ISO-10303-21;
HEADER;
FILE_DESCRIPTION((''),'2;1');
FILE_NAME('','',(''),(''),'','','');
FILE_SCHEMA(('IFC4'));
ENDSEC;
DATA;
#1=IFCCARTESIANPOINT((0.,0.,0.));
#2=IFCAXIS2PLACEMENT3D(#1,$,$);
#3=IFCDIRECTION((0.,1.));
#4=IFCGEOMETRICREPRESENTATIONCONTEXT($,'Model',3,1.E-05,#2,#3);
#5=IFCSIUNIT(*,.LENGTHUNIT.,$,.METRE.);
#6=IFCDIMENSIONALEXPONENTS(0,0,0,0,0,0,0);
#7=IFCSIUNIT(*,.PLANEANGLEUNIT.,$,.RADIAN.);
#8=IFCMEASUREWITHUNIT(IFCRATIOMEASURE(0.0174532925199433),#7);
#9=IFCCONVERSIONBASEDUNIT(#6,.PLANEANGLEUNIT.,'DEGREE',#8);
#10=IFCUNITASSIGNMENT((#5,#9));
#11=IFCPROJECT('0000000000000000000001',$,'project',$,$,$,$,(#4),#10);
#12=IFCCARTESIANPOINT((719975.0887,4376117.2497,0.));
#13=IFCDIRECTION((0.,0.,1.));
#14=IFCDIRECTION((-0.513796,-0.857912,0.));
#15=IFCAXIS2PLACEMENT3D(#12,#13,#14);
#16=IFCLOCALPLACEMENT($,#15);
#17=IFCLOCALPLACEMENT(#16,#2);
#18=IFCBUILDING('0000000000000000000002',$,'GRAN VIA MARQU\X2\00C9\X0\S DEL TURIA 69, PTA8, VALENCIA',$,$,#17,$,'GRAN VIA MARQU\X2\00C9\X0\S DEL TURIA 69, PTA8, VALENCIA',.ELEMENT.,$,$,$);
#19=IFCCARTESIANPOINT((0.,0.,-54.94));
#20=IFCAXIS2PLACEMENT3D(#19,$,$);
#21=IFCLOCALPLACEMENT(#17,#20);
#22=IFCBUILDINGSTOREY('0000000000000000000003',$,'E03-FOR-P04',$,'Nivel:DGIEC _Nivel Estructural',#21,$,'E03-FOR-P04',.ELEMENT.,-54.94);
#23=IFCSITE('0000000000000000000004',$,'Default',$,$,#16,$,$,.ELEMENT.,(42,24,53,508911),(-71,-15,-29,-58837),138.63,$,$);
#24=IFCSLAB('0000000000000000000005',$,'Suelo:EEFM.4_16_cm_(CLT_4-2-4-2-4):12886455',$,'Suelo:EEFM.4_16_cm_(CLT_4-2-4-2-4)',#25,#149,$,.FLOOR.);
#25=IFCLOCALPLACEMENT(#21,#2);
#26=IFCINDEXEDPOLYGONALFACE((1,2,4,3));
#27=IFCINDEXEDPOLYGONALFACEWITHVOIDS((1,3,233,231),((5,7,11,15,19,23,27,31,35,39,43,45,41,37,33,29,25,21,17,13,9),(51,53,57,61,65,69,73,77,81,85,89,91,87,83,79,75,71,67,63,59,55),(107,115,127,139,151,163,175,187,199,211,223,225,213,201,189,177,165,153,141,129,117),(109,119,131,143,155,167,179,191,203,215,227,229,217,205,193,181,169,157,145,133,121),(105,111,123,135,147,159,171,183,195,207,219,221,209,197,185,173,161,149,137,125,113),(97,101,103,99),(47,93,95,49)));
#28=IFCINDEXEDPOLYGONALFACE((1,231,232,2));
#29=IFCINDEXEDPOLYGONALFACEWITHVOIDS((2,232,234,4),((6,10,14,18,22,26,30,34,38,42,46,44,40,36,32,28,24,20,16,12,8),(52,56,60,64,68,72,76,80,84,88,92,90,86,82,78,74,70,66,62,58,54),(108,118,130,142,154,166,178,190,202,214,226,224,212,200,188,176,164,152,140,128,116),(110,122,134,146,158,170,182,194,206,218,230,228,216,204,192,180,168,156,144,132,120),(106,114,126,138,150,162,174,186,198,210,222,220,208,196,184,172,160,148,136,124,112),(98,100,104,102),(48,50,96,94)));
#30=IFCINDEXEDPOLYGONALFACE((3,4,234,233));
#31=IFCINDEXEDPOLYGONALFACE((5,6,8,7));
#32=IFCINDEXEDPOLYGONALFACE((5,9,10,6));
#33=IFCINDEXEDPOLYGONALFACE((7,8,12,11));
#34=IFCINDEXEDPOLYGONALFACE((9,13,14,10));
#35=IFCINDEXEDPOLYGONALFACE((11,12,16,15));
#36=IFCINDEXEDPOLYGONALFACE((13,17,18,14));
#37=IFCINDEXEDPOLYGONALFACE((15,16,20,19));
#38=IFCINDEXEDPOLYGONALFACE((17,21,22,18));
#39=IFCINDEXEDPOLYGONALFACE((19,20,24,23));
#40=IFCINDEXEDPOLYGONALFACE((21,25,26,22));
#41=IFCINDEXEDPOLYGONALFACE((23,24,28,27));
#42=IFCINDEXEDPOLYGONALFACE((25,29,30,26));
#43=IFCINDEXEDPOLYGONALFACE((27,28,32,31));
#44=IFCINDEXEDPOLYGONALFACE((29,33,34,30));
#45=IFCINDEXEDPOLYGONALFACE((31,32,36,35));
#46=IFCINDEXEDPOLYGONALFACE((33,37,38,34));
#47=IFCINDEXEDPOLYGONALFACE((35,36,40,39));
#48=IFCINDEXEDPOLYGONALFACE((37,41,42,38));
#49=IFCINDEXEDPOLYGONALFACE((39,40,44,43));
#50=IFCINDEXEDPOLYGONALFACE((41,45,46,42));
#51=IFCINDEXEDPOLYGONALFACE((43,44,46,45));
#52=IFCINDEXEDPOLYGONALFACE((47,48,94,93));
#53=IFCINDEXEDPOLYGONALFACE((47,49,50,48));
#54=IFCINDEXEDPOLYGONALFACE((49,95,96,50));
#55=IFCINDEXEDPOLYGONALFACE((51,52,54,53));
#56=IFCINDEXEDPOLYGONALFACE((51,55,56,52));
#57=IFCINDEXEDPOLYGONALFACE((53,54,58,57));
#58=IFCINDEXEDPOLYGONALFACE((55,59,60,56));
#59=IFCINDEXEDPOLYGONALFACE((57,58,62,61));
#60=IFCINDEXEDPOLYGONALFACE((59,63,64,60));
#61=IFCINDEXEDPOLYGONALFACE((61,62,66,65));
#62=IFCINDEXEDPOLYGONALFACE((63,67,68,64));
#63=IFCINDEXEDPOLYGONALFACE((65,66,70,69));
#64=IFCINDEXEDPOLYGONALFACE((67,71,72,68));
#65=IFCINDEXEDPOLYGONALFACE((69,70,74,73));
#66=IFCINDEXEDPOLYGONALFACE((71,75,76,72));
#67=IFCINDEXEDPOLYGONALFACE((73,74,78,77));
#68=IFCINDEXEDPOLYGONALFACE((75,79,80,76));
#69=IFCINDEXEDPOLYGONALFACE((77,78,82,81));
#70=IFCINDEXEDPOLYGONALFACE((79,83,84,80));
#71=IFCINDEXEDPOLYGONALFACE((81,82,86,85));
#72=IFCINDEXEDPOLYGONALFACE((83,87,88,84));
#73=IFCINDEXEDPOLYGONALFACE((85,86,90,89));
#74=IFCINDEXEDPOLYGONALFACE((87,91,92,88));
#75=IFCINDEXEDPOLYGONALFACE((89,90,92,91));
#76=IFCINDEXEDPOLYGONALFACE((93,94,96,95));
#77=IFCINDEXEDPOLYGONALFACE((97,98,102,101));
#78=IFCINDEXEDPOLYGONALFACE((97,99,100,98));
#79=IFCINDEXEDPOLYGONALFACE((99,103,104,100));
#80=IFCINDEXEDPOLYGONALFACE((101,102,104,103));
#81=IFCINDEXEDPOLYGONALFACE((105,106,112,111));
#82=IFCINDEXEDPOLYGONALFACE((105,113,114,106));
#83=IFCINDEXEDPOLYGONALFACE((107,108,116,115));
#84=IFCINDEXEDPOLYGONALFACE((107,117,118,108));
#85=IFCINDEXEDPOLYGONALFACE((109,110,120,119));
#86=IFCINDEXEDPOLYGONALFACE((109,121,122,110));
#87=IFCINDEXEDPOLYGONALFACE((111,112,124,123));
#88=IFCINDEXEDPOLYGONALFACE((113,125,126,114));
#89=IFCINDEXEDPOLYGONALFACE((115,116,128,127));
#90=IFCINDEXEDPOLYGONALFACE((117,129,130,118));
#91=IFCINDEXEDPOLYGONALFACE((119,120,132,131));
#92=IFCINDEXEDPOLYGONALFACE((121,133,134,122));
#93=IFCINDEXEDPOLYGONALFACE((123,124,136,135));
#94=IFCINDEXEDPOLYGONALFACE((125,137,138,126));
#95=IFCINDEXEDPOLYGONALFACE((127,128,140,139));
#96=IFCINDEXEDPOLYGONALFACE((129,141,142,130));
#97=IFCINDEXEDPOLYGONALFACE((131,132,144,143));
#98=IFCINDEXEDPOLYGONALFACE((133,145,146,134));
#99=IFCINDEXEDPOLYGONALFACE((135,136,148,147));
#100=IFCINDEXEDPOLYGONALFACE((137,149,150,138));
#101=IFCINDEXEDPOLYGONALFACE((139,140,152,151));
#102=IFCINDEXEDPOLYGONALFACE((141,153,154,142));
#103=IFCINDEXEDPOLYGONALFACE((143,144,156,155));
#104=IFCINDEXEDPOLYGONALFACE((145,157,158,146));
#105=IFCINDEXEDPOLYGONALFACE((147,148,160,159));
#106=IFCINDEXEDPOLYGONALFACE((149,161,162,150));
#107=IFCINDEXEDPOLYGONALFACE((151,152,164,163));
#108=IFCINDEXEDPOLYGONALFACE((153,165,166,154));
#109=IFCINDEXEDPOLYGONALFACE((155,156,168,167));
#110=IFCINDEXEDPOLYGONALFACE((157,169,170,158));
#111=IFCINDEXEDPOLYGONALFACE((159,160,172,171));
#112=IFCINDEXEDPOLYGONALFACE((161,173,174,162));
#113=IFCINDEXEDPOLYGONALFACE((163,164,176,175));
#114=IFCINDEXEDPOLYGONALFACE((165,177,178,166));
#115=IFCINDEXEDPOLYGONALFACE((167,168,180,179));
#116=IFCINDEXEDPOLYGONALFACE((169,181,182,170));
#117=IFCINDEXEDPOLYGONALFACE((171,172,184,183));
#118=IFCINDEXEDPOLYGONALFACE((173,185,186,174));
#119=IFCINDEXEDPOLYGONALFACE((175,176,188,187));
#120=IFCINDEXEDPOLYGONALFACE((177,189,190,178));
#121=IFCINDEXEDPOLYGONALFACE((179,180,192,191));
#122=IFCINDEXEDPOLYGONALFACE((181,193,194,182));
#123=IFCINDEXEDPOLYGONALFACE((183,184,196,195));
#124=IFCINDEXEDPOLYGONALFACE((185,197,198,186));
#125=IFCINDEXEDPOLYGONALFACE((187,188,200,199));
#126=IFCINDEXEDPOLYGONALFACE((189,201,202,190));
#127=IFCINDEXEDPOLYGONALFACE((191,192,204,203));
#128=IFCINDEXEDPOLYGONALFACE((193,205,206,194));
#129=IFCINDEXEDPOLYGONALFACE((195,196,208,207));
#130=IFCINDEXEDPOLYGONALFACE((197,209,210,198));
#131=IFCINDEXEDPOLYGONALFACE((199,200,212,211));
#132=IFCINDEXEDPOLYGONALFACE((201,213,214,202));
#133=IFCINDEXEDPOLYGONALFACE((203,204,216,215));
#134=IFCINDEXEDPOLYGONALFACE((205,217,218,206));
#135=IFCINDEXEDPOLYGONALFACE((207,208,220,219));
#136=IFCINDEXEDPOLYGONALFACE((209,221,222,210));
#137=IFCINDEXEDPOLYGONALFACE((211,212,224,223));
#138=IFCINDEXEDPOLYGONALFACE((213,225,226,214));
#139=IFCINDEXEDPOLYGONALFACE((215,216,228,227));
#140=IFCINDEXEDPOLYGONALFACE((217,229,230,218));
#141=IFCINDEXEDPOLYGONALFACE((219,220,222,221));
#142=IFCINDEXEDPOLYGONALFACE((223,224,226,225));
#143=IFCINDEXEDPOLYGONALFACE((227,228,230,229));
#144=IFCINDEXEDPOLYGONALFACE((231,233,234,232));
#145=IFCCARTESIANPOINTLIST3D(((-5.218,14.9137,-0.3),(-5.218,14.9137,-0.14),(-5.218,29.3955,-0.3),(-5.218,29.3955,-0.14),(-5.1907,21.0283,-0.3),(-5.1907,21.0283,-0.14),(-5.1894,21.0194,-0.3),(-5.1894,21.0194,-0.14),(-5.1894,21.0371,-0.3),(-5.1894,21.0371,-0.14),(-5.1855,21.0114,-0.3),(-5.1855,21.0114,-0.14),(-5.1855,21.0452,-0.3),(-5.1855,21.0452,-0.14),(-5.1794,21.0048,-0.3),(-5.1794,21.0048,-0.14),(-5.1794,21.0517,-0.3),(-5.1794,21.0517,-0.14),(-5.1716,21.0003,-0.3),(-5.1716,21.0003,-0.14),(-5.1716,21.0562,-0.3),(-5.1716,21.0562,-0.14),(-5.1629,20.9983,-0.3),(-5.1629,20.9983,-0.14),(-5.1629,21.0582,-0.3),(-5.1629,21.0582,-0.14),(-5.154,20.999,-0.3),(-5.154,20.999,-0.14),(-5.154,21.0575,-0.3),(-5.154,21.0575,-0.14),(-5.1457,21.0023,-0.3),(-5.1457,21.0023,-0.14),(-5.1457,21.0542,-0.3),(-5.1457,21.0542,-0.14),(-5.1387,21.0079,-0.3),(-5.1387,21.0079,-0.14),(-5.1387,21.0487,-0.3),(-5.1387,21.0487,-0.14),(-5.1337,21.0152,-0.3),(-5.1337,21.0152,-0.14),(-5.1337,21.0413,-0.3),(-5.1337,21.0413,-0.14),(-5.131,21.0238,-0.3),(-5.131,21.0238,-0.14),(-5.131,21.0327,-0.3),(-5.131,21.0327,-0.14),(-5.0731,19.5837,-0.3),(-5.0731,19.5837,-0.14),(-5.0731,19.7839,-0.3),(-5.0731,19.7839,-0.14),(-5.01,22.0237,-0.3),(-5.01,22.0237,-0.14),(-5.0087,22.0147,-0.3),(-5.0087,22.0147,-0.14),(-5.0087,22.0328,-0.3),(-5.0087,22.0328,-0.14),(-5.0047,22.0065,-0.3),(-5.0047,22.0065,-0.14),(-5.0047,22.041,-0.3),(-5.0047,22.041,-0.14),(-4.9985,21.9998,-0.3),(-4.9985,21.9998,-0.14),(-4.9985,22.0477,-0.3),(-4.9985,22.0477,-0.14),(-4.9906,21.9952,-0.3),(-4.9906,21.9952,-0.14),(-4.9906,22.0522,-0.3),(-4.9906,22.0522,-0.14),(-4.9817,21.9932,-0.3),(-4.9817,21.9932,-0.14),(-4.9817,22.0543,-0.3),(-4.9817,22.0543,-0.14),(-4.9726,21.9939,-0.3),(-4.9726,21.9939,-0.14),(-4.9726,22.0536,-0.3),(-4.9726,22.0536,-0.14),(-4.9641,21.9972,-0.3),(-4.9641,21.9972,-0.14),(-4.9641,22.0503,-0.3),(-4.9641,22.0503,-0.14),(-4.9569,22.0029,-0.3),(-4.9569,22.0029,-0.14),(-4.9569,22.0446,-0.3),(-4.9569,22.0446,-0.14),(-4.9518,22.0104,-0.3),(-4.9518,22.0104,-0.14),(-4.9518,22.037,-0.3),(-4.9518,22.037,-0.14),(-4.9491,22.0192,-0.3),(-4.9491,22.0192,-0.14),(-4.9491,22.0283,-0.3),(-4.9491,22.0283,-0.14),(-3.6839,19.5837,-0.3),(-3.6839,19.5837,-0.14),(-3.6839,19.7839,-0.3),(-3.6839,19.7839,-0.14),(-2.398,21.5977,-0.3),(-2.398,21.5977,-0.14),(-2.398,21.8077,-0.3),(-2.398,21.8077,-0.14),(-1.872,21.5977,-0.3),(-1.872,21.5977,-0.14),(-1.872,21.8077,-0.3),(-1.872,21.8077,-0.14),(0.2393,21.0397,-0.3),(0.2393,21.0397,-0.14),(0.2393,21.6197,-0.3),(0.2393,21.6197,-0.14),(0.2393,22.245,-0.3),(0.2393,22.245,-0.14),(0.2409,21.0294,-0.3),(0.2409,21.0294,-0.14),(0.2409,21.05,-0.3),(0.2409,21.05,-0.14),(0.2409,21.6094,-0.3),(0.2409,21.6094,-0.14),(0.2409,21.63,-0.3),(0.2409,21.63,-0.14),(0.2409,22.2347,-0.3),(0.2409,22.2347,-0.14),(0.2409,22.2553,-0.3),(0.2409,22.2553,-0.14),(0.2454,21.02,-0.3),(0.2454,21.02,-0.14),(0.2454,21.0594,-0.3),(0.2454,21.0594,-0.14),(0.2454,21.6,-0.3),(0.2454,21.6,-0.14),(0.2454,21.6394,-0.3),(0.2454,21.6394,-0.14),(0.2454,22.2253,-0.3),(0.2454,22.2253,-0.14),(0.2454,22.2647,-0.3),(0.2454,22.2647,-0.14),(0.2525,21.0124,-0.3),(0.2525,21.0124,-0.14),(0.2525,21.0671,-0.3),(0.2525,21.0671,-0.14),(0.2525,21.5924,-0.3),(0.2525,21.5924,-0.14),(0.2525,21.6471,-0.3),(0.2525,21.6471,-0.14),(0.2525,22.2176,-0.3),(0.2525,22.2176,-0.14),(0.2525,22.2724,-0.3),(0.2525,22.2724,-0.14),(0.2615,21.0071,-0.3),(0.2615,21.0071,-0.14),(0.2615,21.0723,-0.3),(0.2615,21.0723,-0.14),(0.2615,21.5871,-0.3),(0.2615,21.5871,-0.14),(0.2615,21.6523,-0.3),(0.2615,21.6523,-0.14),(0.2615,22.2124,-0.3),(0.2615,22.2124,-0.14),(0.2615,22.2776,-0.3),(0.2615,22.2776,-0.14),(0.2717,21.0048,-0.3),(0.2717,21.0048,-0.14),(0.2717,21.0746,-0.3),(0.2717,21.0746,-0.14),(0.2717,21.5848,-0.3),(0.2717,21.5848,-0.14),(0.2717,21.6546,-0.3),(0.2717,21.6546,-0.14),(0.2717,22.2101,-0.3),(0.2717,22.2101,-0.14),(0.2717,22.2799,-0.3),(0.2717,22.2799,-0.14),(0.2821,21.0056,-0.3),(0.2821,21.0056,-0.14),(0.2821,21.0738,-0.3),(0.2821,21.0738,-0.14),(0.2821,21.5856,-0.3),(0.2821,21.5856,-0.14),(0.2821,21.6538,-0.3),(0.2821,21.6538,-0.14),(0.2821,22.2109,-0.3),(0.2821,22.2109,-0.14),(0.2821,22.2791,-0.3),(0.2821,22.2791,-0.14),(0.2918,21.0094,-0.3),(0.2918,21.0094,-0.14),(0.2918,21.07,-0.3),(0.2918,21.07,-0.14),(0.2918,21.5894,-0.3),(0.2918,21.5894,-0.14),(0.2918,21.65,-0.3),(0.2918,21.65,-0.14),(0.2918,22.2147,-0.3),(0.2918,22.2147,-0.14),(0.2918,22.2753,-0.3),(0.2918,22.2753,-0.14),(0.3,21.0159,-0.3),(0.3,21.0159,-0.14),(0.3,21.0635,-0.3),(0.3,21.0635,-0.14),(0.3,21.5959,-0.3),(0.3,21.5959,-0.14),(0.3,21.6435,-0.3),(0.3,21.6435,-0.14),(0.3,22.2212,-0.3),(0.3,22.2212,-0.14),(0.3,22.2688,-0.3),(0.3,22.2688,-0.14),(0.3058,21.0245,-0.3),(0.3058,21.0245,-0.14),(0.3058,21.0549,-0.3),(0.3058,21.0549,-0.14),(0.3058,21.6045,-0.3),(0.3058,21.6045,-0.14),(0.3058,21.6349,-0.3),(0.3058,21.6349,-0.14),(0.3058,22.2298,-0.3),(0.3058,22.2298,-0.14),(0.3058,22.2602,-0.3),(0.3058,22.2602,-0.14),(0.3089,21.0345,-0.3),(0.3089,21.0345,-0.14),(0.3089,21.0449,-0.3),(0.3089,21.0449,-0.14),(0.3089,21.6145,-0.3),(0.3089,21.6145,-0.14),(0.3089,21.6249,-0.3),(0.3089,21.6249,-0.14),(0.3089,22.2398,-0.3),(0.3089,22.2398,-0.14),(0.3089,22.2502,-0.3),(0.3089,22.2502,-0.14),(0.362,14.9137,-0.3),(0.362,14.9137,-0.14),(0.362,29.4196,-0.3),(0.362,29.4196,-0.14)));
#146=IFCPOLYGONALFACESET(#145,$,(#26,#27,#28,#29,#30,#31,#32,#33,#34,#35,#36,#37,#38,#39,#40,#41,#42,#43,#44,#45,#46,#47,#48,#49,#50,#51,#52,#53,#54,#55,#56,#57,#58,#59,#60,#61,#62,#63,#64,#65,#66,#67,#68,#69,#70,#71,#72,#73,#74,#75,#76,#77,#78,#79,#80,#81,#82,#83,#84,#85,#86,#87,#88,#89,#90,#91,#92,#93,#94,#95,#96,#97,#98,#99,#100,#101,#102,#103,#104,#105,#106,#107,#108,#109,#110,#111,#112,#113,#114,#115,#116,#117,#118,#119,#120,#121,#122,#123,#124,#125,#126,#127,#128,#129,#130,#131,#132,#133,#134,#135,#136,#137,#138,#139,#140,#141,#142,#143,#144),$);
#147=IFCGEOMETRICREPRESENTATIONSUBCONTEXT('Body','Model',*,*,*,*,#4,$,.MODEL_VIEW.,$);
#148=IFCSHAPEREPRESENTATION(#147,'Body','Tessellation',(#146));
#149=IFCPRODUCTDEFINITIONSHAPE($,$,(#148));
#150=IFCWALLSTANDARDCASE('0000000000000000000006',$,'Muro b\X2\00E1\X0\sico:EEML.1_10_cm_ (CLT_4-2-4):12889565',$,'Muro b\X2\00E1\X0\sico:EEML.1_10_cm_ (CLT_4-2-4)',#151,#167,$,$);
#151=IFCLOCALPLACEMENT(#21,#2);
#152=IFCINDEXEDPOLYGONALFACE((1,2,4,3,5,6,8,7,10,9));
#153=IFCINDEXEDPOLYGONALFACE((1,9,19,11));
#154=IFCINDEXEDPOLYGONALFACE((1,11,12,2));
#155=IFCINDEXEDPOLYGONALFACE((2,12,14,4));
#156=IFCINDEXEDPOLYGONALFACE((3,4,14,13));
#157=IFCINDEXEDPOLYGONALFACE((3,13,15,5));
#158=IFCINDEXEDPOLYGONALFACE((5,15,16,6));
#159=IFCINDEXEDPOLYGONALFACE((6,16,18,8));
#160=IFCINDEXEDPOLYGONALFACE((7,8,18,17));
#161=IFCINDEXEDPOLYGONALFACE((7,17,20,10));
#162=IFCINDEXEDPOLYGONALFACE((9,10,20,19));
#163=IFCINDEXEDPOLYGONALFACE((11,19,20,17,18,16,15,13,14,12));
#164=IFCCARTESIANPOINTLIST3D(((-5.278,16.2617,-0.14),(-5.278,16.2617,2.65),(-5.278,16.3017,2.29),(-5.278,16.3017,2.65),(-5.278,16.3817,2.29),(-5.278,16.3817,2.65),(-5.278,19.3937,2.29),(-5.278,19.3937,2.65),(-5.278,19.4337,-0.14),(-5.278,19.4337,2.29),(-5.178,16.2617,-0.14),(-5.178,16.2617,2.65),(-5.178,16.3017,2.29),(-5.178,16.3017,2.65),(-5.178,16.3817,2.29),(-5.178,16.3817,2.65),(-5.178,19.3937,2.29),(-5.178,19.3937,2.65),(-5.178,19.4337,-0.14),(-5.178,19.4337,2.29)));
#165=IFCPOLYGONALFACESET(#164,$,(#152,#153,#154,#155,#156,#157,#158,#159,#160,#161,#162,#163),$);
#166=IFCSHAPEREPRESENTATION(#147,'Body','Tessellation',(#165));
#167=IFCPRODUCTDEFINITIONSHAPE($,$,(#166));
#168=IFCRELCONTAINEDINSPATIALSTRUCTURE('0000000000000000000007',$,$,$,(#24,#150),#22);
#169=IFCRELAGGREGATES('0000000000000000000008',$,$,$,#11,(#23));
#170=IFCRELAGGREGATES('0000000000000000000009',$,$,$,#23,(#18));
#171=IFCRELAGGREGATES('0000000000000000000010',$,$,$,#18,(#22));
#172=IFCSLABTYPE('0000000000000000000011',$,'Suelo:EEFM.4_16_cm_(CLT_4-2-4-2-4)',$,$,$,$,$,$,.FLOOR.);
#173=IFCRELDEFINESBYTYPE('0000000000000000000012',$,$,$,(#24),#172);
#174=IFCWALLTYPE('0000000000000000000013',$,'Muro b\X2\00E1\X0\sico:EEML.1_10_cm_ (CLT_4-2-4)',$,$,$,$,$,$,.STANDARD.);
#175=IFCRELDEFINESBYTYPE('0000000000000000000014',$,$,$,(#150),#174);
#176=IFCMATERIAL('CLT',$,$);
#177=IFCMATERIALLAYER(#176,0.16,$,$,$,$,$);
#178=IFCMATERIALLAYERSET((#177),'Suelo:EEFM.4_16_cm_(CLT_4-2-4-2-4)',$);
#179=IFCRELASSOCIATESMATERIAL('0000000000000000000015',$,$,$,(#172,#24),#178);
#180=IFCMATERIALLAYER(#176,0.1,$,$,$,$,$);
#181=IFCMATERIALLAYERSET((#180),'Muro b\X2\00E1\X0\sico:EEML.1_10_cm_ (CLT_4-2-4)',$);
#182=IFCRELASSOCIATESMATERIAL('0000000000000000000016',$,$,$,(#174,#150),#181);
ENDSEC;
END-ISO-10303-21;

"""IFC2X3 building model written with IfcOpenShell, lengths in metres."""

from ifc_helpers import new_model, entity, si_unit, converted_unit, direction, frame, frame_2d, origin, place, context, subcontext, project, spatial, polyline, rectangle, circle, outline, extrude, material, layer, layer_set, layer_usage, type_object, element, save


model = new_model("IFC2X3")

# Units and contexts
model_context = context("Model", 3, precision=1e-05, world=origin(), true_north=direction((0.0, 1.0)))
body_context = subcontext(model_context, "Body", "Model", "MODEL_VIEW")
ifc_project = project(units=[si_unit("LENGTHUNIT", "METRE"), converted_unit("PLANEANGLEUNIT", "DEGREE", entity("IfcRatioMeasure", 0.0174532925199433), si_unit("PLANEANGLEUNIT", "RADIAN"), dimensions=[0, 0, 0, 0, 0, 0, 0])], contexts=[model_context])

# Site, building, storey
site_placement = place(None, frame((719975.0887, 4376117.2497, 0.0), z_axis=(0.0, 0.0, 1.0), x_axis=(-0.513796, -0.857912, 0.0)))
site = spatial("IfcSite", under=ifc_project, at=site_placement, Name="Default", CompositionType="ELEMENT", RefLatitude=(42, 24, 53, 508911), RefLongitude=(-71, -15, -29, -58837), RefElevation=138.63)
building_placement = place(site_placement, origin())
building = spatial("IfcBuilding", under=site, at=building_placement, Name="GRAN VIA MARQUÉS DEL TURIA 69, PTA8, VALENCIA", LongName="GRAN VIA MARQUÉS DEL TURIA 69, PTA8, VALENCIA", CompositionType="ELEMENT")
storey_placement = place(building_placement, frame((0.0, 0.0, -54.94)))
storey = spatial("IfcBuildingStorey", under=building, at=storey_placement, Name="E03-FOR-P04", ObjectType="Nivel:DGIEC _Nivel Estructural", LongName="E03-FOR-P04", CompositionType="ELEMENT", Elevation=-54.94)

# Slab, openings
ifc_material = material(Name="CLT")
ifc_layer_1 = layer(ifc_material, 0.16)
ifc_layer_set_1 = layer_set([ifc_layer_1], Name="Suelo:EEFM.4_16_cm_(CLT_4-2-4-2-4)")
ifc_layer_usage_1 = layer_usage(ifc_layer_set_1, "AXIS3", "POSITIVE", 0.0)
slab_type_1 = type_object("IfcSlabType", Name="Suelo:EEFM.4_16_cm_(CLT_4-2-4-2-4)", PredefinedType="FLOOR", material=ifc_layer_set_1)
slab_1_placement = place(storey_placement, frame((-5.218, 14.9137, -0.3)))
slab_1 = element("IfcSlab", 1, at=slab_1_placement, inside=storey, type_object=slab_type_1, material=ifc_layer_usage_1, Name="Suelo:EEFM.4_16_cm_(CLT_4-2-4-2-4):12886455", ObjectType="Suelo:EEFM.4_16_cm_(CLT_4-2-4-2-4)", PredefinedType="FLOOR", context=body_context, shape_type="SweptSolid", body=[
    extrude(outline(polyline([(-2.79, 7.2529), (-2.79, -7.2529), (2.79, -7.2529), (2.79, 7.2288), (-2.79, 7.2529)])), frame((2.79, 7.2529, 0.16), z_axis=(0.0, 0.0, -1.0), x_axis=(-1.0, 0.0, 0.0)), (0.0, 0.0, 1.0), 0.16),
])
opening_1_placement = place(storey_placement, frame((-5.218, 14.9137, -0.3)))
element("IfcOpeningElement", 2, at=opening_1_placement, cuts=slab_1, ObjectType="Opening", context=body_context, shape_type="SweptSolid", body=[
    extrude(rectangle(XDim=0.2002, YDim=1.3893, at=frame_2d((1.9505, -2.4829), x_axis=(0.0, -1.0))), frame((2.79, 7.2529, 0.16), z_axis=(0.0, 0.0, -1.0), x_axis=(-1.0, 0.0, 0.0)), (0.0, 0.0, 1.0), 0.16),
])
opening_2_placement = place(storey_placement, frame((-5.218, 14.9137, -0.3)))
element("IfcOpeningElement", 3, at=opening_2_placement, cuts=slab_1, ObjectType="Opening", context=body_context, shape_type="SweptSolid", body=[
    extrude(rectangle(XDim=0.21, YDim=0.5259, at=frame_2d((-0.293, -0.4639), x_axis=(0.0, -1.0))), frame((2.79, 7.2529, 0.16), z_axis=(0.0, 0.0, -1.0), x_axis=(-1.0, 0.0, 0.0)), (0.0, 0.0, 1.0), 0.16),
])
opening_3_placement = place(storey_placement, frame((-5.218, 14.9137, -0.3)))
element("IfcOpeningElement", 4, at=opening_3_placement, cuts=slab_1, ObjectType="Opening", context=body_context, shape_type="SweptSolid", body=[
    extrude(circle(Radius=0.03, at=frame_2d((2.7326, -1.1384), x_axis=(1.0, 0.0))), frame((2.79, 7.2529, 0.16), z_axis=(0.0, 0.0, -1.0), x_axis=(-1.0, 0.0, 0.0)), (0.0, 0.0, 1.0), 0.16),
])
opening_4_placement = place(storey_placement, frame((-5.218, 14.9137, -0.3)))
element("IfcOpeningElement", 5, at=opening_4_placement, cuts=slab_1, ObjectType="Opening", context=body_context, shape_type="SweptSolid", body=[
    extrude(circle(Radius=0.035, at=frame_2d((-2.7024, 0.0784), x_axis=(1.0, 0.0))), frame((2.79, 7.2529, 0.16), z_axis=(0.0, 0.0, -1.0), x_axis=(-1.0, 0.0, 0.0)), (0.0, 0.0, 1.0), 0.16),
])
opening_5_placement = place(storey_placement, frame((-5.218, 14.9137, -0.3)))
element("IfcOpeningElement", 6, at=opening_5_placement, cuts=slab_1, ObjectType="Opening", context=body_context, shape_type="SweptSolid", body=[
    extrude(circle(Radius=0.035, at=frame_2d((-2.7024, -0.5469), x_axis=(1.0, 0.0))), frame((2.79, 7.2529, 0.16), z_axis=(0.0, 0.0, -1.0), x_axis=(-1.0, 0.0, 0.0)), (0.0, 0.0, 1.0), 0.16),
])
opening_6_placement = place(storey_placement, frame((-5.218, 14.9137, -0.3)))
element("IfcOpeningElement", 7, at=opening_6_placement, cuts=slab_1, ObjectType="Opening", context=body_context, shape_type="SweptSolid", body=[
    extrude(circle(Radius=0.035, at=frame_2d((-2.7024, -1.1269), x_axis=(1.0, 0.0))), frame((2.79, 7.2529, 0.16), z_axis=(0.0, 0.0, -1.0), x_axis=(-1.0, 0.0, 0.0)), (0.0, 0.0, 1.0), 0.16),
])
opening_7_placement = place(storey_placement, frame((-5.218, 14.9137, -0.3)))
element("IfcOpeningElement", 8, at=opening_7_placement, cuts=slab_1, ObjectType="Opening", context=body_context, shape_type="SweptSolid", body=[
    extrude(circle(Radius=0.0306, at=frame_2d((2.5513, -0.1429), x_axis=(1.0, 0.0))), frame((2.79, 7.2529, 0.16), z_axis=(0.0, 0.0, -1.0), x_axis=(-1.0, 0.0, 0.0)), (0.0, 0.0, 1.0), 0.16),
])

# Wall, openings
ifc_layer_2 = layer(ifc_material, 0.1)
ifc_layer_set_2 = layer_set([ifc_layer_2], Name="Muro básico:EEML.1_10_cm_ (CLT_4-2-4)")
ifc_layer_usage_2 = layer_usage(ifc_layer_set_2, "AXIS2", "NEGATIVE", 0.05)
wall_type_1 = type_object("IfcWallType", Name="Muro básico:EEML.1_10_cm_ (CLT_4-2-4)", PredefinedType="STANDARD", material=ifc_layer_set_2)
wall_1_placement = place(storey_placement, frame((-5.228, 16.2617, -0.14), z_axis=(0.0, 0.0, 1.0), x_axis=(0.0, 1.0, 0.0)))
wall_1 = element("IfcWallStandardCase", 9, at=wall_1_placement, inside=storey, type_object=wall_type_1, material=ifc_layer_usage_2, Name="Muro básico:EEML.1_10_cm_ (CLT_4-2-4):12889565", ObjectType="Muro básico:EEML.1_10_cm_ (CLT_4-2-4)", context=body_context, shape_type="SweptSolid", body=[
    extrude(rectangle(XDim=3.172, YDim=0.1, at=frame_2d((1.586, 0.0), x_axis=(-1.0, 0.0))), origin(), (0.0, 0.0, 1.0), 2.79),
])
opening_8_placement = place(wall_1_placement, origin())
element("IfcOpeningElement", 10, at=opening_8_placement, cuts=wall_1, ObjectType="Opening", context=body_context, shape_type="SweptSolid", body=[
    extrude(rectangle(XDim=0.36, YDim=0.08, at=frame_2d((0.0, 0.0), x_axis=(1.0, 0.0))), frame((3.172, 0.05, 2.61), z_axis=(0.0, -1.0, 0.0), x_axis=(0.0, 0.0, 1.0)), (0.0, 0.0, 1.0), 0.1),
])
opening_9_placement = place(wall_1_placement, origin())
element("IfcOpeningElement", 11, at=opening_9_placement, cuts=wall_1, ObjectType="Opening", context=body_context, shape_type="SweptSolid", body=[
    extrude(rectangle(XDim=0.36, YDim=0.08, at=frame_2d((0.0, 0.0), x_axis=(0.0, 1.0))), frame((0.08, 0.05, 2.61), z_axis=(0.0, -1.0, 0.0), x_axis=(-1.0, 0.0, 0.0)), (0.0, 0.0, 1.0), 0.1),
])

save(model, "model.ifc")
